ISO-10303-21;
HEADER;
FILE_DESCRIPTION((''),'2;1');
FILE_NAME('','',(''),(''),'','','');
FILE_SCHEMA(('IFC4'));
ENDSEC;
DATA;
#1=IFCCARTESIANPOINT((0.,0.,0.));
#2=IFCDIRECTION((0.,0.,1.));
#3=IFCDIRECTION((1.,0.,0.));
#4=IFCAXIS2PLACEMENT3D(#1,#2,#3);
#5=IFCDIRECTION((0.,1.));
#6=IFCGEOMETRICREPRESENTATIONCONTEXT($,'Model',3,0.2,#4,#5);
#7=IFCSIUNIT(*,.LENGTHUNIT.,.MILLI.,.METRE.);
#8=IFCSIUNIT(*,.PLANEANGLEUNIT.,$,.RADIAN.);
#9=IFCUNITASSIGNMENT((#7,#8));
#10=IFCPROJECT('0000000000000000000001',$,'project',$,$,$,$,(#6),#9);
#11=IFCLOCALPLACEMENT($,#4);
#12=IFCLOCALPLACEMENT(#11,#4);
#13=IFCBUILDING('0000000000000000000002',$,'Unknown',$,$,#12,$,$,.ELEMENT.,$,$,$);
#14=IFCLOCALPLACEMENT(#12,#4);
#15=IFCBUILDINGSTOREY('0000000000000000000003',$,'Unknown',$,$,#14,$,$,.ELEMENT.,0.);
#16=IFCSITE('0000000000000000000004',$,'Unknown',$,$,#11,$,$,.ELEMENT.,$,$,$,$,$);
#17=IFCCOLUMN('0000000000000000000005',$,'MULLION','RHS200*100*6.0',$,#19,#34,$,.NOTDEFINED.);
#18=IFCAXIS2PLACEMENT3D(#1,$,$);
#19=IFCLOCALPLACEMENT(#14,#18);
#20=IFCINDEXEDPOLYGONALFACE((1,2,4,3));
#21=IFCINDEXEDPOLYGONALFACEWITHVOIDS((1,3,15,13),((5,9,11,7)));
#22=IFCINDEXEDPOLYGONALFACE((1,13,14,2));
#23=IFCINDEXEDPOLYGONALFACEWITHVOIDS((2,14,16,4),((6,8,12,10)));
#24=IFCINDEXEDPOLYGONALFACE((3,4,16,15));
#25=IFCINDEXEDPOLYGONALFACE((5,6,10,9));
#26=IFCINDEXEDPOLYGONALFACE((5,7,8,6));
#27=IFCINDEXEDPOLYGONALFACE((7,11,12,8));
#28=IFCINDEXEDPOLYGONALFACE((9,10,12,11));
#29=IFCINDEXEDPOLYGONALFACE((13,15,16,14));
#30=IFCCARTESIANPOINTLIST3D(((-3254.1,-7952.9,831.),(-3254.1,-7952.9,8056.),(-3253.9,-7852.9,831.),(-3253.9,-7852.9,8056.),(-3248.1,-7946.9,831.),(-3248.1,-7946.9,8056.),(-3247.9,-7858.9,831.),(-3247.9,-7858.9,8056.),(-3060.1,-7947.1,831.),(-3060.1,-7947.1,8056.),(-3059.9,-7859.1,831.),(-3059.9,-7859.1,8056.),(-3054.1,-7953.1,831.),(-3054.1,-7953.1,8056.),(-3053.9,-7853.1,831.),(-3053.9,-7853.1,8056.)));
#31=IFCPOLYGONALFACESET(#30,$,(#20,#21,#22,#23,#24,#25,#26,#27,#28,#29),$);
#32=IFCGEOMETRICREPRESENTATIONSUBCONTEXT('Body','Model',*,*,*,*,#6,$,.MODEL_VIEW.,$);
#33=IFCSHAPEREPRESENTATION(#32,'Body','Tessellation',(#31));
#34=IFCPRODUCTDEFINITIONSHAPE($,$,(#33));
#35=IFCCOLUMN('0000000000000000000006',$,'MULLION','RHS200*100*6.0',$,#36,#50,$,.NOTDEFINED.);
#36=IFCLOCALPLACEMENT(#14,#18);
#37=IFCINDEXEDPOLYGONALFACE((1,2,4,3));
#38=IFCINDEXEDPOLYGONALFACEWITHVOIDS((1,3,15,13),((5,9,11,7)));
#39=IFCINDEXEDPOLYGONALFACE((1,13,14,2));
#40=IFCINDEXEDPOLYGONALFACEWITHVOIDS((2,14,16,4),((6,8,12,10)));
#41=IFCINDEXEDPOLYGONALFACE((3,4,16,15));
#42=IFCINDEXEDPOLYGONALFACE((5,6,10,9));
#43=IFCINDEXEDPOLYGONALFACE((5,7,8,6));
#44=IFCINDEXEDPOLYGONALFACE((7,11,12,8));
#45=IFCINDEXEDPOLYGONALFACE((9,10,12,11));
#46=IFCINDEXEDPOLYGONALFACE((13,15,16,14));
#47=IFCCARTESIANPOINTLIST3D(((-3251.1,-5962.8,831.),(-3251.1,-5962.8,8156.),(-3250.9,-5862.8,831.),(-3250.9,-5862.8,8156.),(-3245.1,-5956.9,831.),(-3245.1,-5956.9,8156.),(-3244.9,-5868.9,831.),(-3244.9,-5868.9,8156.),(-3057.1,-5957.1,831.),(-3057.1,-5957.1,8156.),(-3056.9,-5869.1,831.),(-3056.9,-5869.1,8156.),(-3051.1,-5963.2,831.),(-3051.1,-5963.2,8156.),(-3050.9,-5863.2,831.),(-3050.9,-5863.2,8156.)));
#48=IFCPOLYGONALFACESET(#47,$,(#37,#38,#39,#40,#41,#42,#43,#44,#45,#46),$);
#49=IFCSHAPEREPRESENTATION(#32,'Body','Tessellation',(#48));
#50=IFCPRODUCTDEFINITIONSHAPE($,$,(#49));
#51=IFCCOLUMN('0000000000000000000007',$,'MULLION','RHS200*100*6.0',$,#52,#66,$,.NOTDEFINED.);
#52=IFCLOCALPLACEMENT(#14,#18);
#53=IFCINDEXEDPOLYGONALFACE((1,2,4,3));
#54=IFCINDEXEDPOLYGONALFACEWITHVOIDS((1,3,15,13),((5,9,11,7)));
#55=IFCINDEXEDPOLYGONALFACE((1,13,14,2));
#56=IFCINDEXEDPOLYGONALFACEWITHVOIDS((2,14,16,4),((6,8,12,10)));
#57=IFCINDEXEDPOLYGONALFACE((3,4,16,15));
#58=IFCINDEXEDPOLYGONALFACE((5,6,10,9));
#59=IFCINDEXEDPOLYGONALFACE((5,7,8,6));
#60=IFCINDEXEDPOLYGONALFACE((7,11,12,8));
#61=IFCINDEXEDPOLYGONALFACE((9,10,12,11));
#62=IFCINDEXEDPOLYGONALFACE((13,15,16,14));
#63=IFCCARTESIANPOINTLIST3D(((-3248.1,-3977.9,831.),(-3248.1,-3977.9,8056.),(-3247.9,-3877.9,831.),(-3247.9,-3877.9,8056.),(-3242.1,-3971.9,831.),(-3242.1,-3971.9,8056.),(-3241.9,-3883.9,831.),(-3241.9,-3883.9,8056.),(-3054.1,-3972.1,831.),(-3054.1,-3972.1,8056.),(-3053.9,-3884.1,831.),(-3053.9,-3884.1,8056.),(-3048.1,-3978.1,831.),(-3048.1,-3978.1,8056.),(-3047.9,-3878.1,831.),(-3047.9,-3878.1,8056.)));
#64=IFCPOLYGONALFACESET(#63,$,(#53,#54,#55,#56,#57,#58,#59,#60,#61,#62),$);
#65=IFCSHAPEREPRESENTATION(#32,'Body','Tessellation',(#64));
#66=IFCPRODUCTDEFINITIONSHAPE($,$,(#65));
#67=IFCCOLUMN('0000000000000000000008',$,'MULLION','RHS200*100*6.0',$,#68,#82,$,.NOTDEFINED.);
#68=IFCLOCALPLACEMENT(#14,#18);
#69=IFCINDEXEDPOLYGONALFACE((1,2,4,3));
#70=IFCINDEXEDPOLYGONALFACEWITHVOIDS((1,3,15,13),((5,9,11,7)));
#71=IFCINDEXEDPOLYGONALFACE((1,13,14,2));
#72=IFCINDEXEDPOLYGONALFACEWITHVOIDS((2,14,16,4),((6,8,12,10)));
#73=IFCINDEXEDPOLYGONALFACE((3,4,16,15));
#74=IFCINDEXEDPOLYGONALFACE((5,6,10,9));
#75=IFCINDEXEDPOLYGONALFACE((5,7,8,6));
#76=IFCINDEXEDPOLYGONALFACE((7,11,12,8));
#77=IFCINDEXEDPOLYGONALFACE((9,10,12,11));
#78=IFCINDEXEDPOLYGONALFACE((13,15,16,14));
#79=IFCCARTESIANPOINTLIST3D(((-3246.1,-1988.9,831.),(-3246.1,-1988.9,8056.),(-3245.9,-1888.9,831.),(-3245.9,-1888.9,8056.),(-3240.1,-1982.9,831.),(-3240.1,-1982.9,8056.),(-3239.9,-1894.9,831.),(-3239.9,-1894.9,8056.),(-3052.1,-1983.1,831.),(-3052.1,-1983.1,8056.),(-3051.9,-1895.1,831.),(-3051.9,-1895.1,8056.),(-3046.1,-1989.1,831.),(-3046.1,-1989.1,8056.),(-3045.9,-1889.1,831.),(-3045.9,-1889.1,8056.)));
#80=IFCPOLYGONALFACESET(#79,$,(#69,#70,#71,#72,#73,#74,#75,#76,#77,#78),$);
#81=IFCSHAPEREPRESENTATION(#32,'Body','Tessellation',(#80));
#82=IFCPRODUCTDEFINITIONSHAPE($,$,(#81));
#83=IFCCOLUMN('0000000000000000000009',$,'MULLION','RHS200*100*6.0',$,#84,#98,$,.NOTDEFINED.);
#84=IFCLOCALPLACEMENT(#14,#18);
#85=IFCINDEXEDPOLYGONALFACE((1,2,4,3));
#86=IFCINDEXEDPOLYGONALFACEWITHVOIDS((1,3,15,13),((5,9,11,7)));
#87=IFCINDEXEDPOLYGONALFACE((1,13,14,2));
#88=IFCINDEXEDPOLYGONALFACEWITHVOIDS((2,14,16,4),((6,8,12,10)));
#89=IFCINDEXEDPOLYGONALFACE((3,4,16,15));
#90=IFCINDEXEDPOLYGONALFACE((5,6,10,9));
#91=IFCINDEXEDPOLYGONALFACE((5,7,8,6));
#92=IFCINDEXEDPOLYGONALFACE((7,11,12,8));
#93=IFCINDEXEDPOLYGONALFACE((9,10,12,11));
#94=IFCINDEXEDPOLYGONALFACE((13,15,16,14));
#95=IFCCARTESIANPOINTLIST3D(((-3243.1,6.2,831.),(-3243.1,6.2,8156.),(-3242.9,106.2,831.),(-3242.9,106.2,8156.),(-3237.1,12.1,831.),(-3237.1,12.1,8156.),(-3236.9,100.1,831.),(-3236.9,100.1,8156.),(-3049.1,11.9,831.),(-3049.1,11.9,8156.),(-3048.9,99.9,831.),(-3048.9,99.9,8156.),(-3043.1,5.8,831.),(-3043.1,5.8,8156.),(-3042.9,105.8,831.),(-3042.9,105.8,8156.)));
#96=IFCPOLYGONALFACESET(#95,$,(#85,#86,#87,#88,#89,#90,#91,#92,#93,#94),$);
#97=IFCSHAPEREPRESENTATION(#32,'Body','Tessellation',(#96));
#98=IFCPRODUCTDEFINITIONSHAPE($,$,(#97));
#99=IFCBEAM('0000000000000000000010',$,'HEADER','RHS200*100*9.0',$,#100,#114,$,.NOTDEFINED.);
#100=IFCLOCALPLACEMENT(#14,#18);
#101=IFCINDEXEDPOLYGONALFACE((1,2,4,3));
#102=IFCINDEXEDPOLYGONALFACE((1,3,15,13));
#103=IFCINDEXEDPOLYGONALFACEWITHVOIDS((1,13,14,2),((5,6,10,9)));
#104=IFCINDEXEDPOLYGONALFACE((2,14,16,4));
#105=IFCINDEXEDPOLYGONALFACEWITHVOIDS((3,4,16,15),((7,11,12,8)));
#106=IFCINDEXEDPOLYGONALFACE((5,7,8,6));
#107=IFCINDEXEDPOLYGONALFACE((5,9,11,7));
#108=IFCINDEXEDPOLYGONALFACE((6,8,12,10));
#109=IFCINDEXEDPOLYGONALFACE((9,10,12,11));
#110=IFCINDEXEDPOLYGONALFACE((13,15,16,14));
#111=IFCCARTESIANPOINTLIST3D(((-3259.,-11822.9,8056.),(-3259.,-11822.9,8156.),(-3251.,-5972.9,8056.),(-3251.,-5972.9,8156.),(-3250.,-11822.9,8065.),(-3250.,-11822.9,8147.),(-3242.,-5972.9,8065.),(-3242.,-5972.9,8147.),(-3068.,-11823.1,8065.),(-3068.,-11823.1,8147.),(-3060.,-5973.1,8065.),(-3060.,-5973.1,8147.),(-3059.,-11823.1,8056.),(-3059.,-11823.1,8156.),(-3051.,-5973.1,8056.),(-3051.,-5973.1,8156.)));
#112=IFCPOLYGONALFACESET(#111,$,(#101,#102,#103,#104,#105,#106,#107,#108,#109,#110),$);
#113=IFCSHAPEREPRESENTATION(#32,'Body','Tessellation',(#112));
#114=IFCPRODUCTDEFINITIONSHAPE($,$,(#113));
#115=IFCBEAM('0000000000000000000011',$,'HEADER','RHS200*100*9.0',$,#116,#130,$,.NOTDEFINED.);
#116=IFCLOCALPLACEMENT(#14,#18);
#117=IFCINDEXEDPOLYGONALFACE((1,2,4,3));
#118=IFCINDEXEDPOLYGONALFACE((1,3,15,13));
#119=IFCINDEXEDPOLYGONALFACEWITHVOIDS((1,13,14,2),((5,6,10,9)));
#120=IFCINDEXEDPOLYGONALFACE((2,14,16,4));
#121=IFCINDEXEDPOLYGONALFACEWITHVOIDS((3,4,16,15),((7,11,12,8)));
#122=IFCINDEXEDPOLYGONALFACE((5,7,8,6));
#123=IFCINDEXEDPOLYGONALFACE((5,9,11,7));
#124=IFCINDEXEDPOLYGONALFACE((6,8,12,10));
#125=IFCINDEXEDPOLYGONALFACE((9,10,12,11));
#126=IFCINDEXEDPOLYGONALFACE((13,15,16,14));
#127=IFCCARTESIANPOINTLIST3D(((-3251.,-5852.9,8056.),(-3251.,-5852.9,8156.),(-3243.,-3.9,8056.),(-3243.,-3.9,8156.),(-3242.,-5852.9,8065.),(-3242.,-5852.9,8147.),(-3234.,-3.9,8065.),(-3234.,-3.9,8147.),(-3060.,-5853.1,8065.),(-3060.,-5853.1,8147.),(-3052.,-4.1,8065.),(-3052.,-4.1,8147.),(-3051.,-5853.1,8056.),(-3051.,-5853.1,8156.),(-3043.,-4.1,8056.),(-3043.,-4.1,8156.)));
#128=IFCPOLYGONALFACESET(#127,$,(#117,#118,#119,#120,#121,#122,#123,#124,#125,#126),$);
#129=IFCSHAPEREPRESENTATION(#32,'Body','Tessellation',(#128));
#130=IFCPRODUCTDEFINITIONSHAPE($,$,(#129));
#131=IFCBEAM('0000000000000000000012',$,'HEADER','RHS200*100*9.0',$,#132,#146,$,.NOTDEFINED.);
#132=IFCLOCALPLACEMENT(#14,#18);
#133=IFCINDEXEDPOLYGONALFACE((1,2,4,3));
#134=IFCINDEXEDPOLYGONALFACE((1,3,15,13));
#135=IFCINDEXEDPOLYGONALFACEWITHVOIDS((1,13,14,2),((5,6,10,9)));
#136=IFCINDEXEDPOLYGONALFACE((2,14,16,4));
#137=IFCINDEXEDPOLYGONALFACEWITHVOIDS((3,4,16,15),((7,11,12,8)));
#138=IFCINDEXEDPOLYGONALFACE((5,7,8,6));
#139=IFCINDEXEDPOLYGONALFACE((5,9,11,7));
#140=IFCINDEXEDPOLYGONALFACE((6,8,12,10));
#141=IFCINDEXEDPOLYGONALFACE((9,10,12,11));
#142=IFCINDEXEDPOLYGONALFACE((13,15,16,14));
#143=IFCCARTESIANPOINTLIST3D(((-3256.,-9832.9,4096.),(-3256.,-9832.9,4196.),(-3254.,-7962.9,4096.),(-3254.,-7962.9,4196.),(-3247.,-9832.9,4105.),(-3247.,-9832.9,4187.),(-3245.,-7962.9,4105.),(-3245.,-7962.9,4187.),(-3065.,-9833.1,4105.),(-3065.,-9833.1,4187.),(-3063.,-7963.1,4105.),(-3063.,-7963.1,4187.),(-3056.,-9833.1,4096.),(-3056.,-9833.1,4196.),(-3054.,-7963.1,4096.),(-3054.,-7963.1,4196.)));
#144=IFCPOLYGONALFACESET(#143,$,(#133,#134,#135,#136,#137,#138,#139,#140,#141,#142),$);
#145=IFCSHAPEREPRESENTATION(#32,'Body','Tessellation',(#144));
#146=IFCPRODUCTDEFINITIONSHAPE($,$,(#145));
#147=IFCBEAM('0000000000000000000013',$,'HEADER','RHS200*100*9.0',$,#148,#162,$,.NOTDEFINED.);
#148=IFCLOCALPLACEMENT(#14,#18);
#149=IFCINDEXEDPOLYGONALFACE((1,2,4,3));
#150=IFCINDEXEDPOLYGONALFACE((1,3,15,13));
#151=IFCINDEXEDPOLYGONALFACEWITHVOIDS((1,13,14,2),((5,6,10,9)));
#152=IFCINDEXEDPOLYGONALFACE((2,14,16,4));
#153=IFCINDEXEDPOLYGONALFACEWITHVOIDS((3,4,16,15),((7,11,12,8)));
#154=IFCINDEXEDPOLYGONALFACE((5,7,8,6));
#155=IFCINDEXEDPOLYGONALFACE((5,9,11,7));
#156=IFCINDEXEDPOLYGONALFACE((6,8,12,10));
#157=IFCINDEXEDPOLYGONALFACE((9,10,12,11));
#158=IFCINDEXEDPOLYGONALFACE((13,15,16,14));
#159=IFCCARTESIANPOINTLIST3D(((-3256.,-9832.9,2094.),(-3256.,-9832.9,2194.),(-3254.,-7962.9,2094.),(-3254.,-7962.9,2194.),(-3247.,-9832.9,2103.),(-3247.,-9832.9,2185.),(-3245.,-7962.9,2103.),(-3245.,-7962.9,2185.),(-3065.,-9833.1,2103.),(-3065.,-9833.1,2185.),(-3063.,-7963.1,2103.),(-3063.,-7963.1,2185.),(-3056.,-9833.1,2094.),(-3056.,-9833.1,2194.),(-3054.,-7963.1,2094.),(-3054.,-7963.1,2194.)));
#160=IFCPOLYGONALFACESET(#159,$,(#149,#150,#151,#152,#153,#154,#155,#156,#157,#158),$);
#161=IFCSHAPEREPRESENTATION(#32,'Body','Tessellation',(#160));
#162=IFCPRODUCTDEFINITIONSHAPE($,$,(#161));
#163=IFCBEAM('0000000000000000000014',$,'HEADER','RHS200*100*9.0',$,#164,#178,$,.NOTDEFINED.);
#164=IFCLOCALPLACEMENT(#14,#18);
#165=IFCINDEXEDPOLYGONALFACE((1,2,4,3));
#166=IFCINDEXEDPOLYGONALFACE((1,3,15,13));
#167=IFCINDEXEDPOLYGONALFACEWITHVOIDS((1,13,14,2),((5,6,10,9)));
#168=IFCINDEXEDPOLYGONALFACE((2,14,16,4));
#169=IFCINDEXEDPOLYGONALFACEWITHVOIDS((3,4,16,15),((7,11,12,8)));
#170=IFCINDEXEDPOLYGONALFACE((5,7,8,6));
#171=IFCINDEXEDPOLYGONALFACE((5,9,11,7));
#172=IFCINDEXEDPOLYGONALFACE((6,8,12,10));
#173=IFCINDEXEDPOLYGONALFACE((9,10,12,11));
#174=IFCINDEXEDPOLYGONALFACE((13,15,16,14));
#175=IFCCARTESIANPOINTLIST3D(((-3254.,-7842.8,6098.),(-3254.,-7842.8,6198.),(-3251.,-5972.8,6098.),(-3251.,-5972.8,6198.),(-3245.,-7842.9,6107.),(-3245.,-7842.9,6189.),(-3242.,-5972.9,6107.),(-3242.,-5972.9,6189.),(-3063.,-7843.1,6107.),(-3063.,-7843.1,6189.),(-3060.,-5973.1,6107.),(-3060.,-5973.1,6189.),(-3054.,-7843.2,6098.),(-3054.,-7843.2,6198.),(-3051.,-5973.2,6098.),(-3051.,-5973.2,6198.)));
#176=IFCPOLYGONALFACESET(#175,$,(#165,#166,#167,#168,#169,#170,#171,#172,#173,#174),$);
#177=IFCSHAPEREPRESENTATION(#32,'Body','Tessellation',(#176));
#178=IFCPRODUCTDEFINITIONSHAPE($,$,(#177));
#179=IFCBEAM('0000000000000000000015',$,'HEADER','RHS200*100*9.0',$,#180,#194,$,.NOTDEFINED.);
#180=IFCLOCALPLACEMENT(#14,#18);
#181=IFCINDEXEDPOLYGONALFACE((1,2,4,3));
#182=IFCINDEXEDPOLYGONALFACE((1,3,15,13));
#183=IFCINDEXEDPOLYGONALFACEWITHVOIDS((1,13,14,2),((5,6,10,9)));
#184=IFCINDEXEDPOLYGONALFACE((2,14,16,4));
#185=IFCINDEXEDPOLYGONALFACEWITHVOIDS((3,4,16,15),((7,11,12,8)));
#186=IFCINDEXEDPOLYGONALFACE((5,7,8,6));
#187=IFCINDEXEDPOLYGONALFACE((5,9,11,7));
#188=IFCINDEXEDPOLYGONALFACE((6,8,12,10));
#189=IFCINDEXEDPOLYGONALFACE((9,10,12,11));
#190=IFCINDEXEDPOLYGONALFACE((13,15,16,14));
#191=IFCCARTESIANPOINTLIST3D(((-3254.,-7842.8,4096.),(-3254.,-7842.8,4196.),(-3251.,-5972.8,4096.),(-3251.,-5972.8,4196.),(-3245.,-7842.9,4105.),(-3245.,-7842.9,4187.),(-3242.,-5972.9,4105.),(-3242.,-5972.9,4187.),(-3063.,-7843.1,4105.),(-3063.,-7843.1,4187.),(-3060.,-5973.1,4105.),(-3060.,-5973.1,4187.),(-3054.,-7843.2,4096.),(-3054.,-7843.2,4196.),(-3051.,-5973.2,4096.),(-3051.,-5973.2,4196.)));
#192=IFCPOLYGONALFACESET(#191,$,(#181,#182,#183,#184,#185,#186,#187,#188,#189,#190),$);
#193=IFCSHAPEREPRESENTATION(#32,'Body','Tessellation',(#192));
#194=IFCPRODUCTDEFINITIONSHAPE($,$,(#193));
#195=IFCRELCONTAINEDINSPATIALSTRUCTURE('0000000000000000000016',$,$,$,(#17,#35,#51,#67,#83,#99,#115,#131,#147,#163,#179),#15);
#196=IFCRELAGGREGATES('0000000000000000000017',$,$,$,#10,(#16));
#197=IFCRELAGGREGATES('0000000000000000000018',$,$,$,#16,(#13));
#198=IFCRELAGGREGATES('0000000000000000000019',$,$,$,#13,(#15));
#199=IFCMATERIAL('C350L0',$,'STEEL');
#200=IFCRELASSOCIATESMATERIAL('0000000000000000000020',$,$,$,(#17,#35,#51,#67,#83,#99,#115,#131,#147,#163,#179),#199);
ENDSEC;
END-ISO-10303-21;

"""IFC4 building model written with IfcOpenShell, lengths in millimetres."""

from ifc_helpers import new_model, si_unit, direction, frame, origin_with_axes, place, context, subcontext, project, spatial, line, indexed_curve, outline, extrude, material, element, save


model = new_model("IFC4")

# Units and contexts
model_context = context("Model", 3, precision=0.2, world=origin_with_axes(), true_north=direction((0.0, 1.0)))
body_context = subcontext(model_context, "Body", "Model", "MODEL_VIEW")
ifc_project = project(units=[si_unit("LENGTHUNIT", "METRE", prefix="MILLI"), si_unit("PLANEANGLEUNIT", "RADIAN")], contexts=[model_context])

# Site, building, storey
site_placement = place(None, origin_with_axes())
site = spatial("IfcSite", under=ifc_project, at=site_placement, Name="Unknown", CompositionType="ELEMENT")
building_placement = place(site_placement, origin_with_axes())
building = spatial("IfcBuilding", under=site, at=building_placement, Name="Unknown", CompositionType="ELEMENT")
storey_placement = place(building_placement, origin_with_axes())
storey = spatial("IfcBuildingStorey", under=building, at=storey_placement, Name="Unknown", CompositionType="ELEMENT", Elevation=0.0)

# Columns
ifc_material = material(Name="C350L0", Category="STEEL")
column_1_placement = place(storey_placement, frame((-3154.0, -7903.0, 831.0), z_axis=(0.001396, 0.999999, 0.0), x_axis=(0.0, 0.0, 1.0)))
element("IfcColumn", 1, at=column_1_placement, inside=storey, material=ifc_material, Name="MULLION", Description="RHS200*100*6.0", PredefinedType="NOTDEFINED", context=body_context, shape_type="SolidModel", body=[
    extrude(outline(indexed_curve([(-50.0, -100.0), (50.0, -100.0), (50.0, 100.0), (-50.0, 100.0)], segments=[line(1, 2, 3, 4, 1)]), holes=[indexed_curve([(-44.0, -94.0), (-44.0, 94.0), (44.0, 94.0), (44.0, -94.0)], segments=[line(1, 2, 3, 4, 1)])]), frame((0.0, 0.0, 0.0), z_axis=(-1.0, 0.0, 0.0), x_axis=(0.0, 0.0, 1.0)), (0.0, 0.0, -1.0), 7225.0),
])
column_2_placement = place(storey_placement, frame((-3151.0, -5913.0, 831.0), z_axis=(0.001571, 0.999999, 0.0), x_axis=(0.0, 0.0, 1.0)))
element("IfcColumn", 2, at=column_2_placement, inside=storey, material=ifc_material, Name="MULLION", Description="RHS200*100*6.0", PredefinedType="NOTDEFINED", context=body_context, shape_type="SolidModel", body=[
    extrude(outline(indexed_curve([(-50.0, -100.0), (50.0, -100.0), (50.0, 100.0), (-50.0, 100.0)], segments=[line(1, 2, 3, 4, 1)]), holes=[indexed_curve([(-44.0, -94.0), (-44.0, 94.0), (44.0, 94.0), (44.0, -94.0)], segments=[line(1, 2, 3, 4, 1)])]), frame((0.0, 0.0, 0.0), z_axis=(-1.0, 0.0, 0.0), x_axis=(0.0, 0.0, 1.0)), (0.0, 0.0, -1.0), 7325.0),
])
for number, where, z_axis, x_axis, name in (
    (3, (-3148.0, -3928.0, 831.0), (0.001396, 0.999999, 0.0), (0.0, 0.0, 1.0), "MULLION"),
    (4, (-3146.0, -1939.0, 831.0), (0.001396, 0.999999, 0.0), (0.0, 0.0, 1.0), "MULLION"),
):
    element("IfcColumn", number, at=place(storey_placement, frame(where, z_axis=z_axis, x_axis=x_axis)), inside=storey, material=ifc_material, Name=name, Description="RHS200*100*6.0", PredefinedType="NOTDEFINED", context=body_context, shape_type="SolidModel", body=[
        extrude(outline(indexed_curve([(-50.0, -100.0), (50.0, -100.0), (50.0, 100.0), (-50.0, 100.0)], segments=[line(1, 2, 3, 4, 1)]), holes=[indexed_curve([(-44.0, -94.0), (-44.0, 94.0), (44.0, 94.0), (44.0, -94.0)], segments=[line(1, 2, 3, 4, 1)])]), frame((0.0, 0.0, 0.0), z_axis=(-1.0, 0.0, 0.0), x_axis=(0.0, 0.0, 1.0)), (0.0, 0.0, -1.0), 7225.0),
    ])
column_3_placement = place(storey_placement, frame((-3143.0, 56.0, 831.0), z_axis=(0.001571, 0.999999, 0.0), x_axis=(0.0, 0.0, 1.0)))
element("IfcColumn", 5, at=column_3_placement, inside=storey, material=ifc_material, Name="MULLION", Description="RHS200*100*6.0", PredefinedType="NOTDEFINED", context=body_context, shape_type="SolidModel", body=[
    extrude(outline(indexed_curve([(-50.0, -100.0), (50.0, -100.0), (50.0, 100.0), (-50.0, 100.0)], segments=[line(1, 2, 3, 4, 1)]), holes=[indexed_curve([(-44.0, -94.0), (-44.0, 94.0), (44.0, 94.0), (44.0, -94.0)], segments=[line(1, 2, 3, 4, 1)])]), frame((0.0, 0.0, 0.0), z_axis=(-1.0, 0.0, 0.0), x_axis=(0.0, 0.0, 1.0)), (0.0, 0.0, -1.0), 7325.0),
])

# Beams
beam_1_placement = place(storey_placement, frame((-3151.0, -5973.0, 8106.0), z_axis=(0.0, 0.0, 1.0), x_axis=(-0.001368, -0.999999, 0.0)))
element("IfcBeam", 6, at=beam_1_placement, inside=storey, material=ifc_material, Name="HEADER", Description="RHS200*100*9.0", PredefinedType="NOTDEFINED", context=body_context, shape_type="SolidModel", body=[
    extrude(outline(indexed_curve([(-50.0, -100.0), (50.0, -100.0), (50.0, 100.0), (-50.0, 100.0)], segments=[line(1, 2, 3, 4, 1)]), holes=[indexed_curve([(-41.0, -91.0), (-41.0, 91.0), (41.0, 91.0), (41.0, -91.0)], segments=[line(1, 2, 3, 4, 1)])]), frame((0.0, 0.0, 0.0), z_axis=(-1.0, 0.0, 0.0), x_axis=(0.0, 0.0, 1.0)), (0.0, 0.0, -1.0), 5850.0),
])
beam_2_placement = place(storey_placement, frame((-3143.0, -4.0, 8106.0), z_axis=(0.0, 0.0, 1.0), x_axis=(-0.001368, -0.999999, 0.0)))
element("IfcBeam", 7, at=beam_2_placement, inside=storey, material=ifc_material, Name="HEADER", Description="RHS200*100*9.0", PredefinedType="NOTDEFINED", context=body_context, shape_type="SolidModel", body=[
    extrude(outline(indexed_curve([(-50.0, -100.0), (50.0, -100.0), (50.0, 100.0), (-50.0, 100.0)], segments=[line(1, 2, 3, 4, 1)]), holes=[indexed_curve([(-41.0, -91.0), (-41.0, 91.0), (41.0, 91.0), (41.0, -91.0)], segments=[line(1, 2, 3, 4, 1)])]), frame((0.0, 0.0, 0.0), z_axis=(-1.0, 0.0, 0.0), x_axis=(0.0, 0.0, 1.0)), (0.0, 0.0, -1.0), 5849.0),
])
for number, where, z_axis, x_axis, name in (
    (8, (-3154.0, -7963.0, 4146.0), (0.0, 0.0, 1.0), (-0.00107, -0.999999, 0.0), "HEADER"),
    (9, (-3154.0, -7963.0, 2144.0), (0.0, 0.0, 1.0), (-0.00107, -0.999999, 0.0), "HEADER"),
):
    element("IfcBeam", number, at=place(storey_placement, frame(where, z_axis=z_axis, x_axis=x_axis)), inside=storey, material=ifc_material, Name=name, Description="RHS200*100*9.0", PredefinedType="NOTDEFINED", context=body_context, shape_type="SolidModel", body=[
        extrude(outline(indexed_curve([(-50.0, -100.0), (50.0, -100.0), (50.0, 100.0), (-50.0, 100.0)], segments=[line(1, 2, 3, 4, 1)]), holes=[indexed_curve([(-41.0, -91.0), (-41.0, 91.0), (41.0, 91.0), (41.0, -91.0)], segments=[line(1, 2, 3, 4, 1)])]), frame((0.0, 0.0, 0.0), z_axis=(-1.0, 0.0, 0.0), x_axis=(0.0, 0.0, 1.0)), (0.0, 0.0, -1.0), 1870.0),
    ])
for number, where, z_axis, x_axis, name in (
    (10, (-3151.0, -5973.0, 6148.0), (0.0, 0.0, 1.0), (-0.001604, -0.999999, 0.0), "HEADER"),
    (11, (-3151.0, -5973.0, 4146.0), (0.0, 0.0, 1.0), (-0.001604, -0.999999, 0.0), "HEADER"),
):
    element("IfcBeam", number, at=place(storey_placement, frame(where, z_axis=z_axis, x_axis=x_axis)), inside=storey, material=ifc_material, Name=name, Description="RHS200*100*9.0", PredefinedType="NOTDEFINED", context=body_context, shape_type="SolidModel", body=[
        extrude(outline(indexed_curve([(-50.0, -100.0), (50.0, -100.0), (50.0, 100.0), (-50.0, 100.0)], segments=[line(1, 2, 3, 4, 1)]), holes=[indexed_curve([(-41.0, -91.0), (-41.0, 91.0), (41.0, 91.0), (41.0, -91.0)], segments=[line(1, 2, 3, 4, 1)])]), frame((0.0, 0.0, 0.0), z_axis=(-1.0, 0.0, 0.0), x_axis=(0.0, 0.0, 1.0)), (0.0, 0.0, -1.0), 1870.0),
    ])

save(model, "model.ifc")
